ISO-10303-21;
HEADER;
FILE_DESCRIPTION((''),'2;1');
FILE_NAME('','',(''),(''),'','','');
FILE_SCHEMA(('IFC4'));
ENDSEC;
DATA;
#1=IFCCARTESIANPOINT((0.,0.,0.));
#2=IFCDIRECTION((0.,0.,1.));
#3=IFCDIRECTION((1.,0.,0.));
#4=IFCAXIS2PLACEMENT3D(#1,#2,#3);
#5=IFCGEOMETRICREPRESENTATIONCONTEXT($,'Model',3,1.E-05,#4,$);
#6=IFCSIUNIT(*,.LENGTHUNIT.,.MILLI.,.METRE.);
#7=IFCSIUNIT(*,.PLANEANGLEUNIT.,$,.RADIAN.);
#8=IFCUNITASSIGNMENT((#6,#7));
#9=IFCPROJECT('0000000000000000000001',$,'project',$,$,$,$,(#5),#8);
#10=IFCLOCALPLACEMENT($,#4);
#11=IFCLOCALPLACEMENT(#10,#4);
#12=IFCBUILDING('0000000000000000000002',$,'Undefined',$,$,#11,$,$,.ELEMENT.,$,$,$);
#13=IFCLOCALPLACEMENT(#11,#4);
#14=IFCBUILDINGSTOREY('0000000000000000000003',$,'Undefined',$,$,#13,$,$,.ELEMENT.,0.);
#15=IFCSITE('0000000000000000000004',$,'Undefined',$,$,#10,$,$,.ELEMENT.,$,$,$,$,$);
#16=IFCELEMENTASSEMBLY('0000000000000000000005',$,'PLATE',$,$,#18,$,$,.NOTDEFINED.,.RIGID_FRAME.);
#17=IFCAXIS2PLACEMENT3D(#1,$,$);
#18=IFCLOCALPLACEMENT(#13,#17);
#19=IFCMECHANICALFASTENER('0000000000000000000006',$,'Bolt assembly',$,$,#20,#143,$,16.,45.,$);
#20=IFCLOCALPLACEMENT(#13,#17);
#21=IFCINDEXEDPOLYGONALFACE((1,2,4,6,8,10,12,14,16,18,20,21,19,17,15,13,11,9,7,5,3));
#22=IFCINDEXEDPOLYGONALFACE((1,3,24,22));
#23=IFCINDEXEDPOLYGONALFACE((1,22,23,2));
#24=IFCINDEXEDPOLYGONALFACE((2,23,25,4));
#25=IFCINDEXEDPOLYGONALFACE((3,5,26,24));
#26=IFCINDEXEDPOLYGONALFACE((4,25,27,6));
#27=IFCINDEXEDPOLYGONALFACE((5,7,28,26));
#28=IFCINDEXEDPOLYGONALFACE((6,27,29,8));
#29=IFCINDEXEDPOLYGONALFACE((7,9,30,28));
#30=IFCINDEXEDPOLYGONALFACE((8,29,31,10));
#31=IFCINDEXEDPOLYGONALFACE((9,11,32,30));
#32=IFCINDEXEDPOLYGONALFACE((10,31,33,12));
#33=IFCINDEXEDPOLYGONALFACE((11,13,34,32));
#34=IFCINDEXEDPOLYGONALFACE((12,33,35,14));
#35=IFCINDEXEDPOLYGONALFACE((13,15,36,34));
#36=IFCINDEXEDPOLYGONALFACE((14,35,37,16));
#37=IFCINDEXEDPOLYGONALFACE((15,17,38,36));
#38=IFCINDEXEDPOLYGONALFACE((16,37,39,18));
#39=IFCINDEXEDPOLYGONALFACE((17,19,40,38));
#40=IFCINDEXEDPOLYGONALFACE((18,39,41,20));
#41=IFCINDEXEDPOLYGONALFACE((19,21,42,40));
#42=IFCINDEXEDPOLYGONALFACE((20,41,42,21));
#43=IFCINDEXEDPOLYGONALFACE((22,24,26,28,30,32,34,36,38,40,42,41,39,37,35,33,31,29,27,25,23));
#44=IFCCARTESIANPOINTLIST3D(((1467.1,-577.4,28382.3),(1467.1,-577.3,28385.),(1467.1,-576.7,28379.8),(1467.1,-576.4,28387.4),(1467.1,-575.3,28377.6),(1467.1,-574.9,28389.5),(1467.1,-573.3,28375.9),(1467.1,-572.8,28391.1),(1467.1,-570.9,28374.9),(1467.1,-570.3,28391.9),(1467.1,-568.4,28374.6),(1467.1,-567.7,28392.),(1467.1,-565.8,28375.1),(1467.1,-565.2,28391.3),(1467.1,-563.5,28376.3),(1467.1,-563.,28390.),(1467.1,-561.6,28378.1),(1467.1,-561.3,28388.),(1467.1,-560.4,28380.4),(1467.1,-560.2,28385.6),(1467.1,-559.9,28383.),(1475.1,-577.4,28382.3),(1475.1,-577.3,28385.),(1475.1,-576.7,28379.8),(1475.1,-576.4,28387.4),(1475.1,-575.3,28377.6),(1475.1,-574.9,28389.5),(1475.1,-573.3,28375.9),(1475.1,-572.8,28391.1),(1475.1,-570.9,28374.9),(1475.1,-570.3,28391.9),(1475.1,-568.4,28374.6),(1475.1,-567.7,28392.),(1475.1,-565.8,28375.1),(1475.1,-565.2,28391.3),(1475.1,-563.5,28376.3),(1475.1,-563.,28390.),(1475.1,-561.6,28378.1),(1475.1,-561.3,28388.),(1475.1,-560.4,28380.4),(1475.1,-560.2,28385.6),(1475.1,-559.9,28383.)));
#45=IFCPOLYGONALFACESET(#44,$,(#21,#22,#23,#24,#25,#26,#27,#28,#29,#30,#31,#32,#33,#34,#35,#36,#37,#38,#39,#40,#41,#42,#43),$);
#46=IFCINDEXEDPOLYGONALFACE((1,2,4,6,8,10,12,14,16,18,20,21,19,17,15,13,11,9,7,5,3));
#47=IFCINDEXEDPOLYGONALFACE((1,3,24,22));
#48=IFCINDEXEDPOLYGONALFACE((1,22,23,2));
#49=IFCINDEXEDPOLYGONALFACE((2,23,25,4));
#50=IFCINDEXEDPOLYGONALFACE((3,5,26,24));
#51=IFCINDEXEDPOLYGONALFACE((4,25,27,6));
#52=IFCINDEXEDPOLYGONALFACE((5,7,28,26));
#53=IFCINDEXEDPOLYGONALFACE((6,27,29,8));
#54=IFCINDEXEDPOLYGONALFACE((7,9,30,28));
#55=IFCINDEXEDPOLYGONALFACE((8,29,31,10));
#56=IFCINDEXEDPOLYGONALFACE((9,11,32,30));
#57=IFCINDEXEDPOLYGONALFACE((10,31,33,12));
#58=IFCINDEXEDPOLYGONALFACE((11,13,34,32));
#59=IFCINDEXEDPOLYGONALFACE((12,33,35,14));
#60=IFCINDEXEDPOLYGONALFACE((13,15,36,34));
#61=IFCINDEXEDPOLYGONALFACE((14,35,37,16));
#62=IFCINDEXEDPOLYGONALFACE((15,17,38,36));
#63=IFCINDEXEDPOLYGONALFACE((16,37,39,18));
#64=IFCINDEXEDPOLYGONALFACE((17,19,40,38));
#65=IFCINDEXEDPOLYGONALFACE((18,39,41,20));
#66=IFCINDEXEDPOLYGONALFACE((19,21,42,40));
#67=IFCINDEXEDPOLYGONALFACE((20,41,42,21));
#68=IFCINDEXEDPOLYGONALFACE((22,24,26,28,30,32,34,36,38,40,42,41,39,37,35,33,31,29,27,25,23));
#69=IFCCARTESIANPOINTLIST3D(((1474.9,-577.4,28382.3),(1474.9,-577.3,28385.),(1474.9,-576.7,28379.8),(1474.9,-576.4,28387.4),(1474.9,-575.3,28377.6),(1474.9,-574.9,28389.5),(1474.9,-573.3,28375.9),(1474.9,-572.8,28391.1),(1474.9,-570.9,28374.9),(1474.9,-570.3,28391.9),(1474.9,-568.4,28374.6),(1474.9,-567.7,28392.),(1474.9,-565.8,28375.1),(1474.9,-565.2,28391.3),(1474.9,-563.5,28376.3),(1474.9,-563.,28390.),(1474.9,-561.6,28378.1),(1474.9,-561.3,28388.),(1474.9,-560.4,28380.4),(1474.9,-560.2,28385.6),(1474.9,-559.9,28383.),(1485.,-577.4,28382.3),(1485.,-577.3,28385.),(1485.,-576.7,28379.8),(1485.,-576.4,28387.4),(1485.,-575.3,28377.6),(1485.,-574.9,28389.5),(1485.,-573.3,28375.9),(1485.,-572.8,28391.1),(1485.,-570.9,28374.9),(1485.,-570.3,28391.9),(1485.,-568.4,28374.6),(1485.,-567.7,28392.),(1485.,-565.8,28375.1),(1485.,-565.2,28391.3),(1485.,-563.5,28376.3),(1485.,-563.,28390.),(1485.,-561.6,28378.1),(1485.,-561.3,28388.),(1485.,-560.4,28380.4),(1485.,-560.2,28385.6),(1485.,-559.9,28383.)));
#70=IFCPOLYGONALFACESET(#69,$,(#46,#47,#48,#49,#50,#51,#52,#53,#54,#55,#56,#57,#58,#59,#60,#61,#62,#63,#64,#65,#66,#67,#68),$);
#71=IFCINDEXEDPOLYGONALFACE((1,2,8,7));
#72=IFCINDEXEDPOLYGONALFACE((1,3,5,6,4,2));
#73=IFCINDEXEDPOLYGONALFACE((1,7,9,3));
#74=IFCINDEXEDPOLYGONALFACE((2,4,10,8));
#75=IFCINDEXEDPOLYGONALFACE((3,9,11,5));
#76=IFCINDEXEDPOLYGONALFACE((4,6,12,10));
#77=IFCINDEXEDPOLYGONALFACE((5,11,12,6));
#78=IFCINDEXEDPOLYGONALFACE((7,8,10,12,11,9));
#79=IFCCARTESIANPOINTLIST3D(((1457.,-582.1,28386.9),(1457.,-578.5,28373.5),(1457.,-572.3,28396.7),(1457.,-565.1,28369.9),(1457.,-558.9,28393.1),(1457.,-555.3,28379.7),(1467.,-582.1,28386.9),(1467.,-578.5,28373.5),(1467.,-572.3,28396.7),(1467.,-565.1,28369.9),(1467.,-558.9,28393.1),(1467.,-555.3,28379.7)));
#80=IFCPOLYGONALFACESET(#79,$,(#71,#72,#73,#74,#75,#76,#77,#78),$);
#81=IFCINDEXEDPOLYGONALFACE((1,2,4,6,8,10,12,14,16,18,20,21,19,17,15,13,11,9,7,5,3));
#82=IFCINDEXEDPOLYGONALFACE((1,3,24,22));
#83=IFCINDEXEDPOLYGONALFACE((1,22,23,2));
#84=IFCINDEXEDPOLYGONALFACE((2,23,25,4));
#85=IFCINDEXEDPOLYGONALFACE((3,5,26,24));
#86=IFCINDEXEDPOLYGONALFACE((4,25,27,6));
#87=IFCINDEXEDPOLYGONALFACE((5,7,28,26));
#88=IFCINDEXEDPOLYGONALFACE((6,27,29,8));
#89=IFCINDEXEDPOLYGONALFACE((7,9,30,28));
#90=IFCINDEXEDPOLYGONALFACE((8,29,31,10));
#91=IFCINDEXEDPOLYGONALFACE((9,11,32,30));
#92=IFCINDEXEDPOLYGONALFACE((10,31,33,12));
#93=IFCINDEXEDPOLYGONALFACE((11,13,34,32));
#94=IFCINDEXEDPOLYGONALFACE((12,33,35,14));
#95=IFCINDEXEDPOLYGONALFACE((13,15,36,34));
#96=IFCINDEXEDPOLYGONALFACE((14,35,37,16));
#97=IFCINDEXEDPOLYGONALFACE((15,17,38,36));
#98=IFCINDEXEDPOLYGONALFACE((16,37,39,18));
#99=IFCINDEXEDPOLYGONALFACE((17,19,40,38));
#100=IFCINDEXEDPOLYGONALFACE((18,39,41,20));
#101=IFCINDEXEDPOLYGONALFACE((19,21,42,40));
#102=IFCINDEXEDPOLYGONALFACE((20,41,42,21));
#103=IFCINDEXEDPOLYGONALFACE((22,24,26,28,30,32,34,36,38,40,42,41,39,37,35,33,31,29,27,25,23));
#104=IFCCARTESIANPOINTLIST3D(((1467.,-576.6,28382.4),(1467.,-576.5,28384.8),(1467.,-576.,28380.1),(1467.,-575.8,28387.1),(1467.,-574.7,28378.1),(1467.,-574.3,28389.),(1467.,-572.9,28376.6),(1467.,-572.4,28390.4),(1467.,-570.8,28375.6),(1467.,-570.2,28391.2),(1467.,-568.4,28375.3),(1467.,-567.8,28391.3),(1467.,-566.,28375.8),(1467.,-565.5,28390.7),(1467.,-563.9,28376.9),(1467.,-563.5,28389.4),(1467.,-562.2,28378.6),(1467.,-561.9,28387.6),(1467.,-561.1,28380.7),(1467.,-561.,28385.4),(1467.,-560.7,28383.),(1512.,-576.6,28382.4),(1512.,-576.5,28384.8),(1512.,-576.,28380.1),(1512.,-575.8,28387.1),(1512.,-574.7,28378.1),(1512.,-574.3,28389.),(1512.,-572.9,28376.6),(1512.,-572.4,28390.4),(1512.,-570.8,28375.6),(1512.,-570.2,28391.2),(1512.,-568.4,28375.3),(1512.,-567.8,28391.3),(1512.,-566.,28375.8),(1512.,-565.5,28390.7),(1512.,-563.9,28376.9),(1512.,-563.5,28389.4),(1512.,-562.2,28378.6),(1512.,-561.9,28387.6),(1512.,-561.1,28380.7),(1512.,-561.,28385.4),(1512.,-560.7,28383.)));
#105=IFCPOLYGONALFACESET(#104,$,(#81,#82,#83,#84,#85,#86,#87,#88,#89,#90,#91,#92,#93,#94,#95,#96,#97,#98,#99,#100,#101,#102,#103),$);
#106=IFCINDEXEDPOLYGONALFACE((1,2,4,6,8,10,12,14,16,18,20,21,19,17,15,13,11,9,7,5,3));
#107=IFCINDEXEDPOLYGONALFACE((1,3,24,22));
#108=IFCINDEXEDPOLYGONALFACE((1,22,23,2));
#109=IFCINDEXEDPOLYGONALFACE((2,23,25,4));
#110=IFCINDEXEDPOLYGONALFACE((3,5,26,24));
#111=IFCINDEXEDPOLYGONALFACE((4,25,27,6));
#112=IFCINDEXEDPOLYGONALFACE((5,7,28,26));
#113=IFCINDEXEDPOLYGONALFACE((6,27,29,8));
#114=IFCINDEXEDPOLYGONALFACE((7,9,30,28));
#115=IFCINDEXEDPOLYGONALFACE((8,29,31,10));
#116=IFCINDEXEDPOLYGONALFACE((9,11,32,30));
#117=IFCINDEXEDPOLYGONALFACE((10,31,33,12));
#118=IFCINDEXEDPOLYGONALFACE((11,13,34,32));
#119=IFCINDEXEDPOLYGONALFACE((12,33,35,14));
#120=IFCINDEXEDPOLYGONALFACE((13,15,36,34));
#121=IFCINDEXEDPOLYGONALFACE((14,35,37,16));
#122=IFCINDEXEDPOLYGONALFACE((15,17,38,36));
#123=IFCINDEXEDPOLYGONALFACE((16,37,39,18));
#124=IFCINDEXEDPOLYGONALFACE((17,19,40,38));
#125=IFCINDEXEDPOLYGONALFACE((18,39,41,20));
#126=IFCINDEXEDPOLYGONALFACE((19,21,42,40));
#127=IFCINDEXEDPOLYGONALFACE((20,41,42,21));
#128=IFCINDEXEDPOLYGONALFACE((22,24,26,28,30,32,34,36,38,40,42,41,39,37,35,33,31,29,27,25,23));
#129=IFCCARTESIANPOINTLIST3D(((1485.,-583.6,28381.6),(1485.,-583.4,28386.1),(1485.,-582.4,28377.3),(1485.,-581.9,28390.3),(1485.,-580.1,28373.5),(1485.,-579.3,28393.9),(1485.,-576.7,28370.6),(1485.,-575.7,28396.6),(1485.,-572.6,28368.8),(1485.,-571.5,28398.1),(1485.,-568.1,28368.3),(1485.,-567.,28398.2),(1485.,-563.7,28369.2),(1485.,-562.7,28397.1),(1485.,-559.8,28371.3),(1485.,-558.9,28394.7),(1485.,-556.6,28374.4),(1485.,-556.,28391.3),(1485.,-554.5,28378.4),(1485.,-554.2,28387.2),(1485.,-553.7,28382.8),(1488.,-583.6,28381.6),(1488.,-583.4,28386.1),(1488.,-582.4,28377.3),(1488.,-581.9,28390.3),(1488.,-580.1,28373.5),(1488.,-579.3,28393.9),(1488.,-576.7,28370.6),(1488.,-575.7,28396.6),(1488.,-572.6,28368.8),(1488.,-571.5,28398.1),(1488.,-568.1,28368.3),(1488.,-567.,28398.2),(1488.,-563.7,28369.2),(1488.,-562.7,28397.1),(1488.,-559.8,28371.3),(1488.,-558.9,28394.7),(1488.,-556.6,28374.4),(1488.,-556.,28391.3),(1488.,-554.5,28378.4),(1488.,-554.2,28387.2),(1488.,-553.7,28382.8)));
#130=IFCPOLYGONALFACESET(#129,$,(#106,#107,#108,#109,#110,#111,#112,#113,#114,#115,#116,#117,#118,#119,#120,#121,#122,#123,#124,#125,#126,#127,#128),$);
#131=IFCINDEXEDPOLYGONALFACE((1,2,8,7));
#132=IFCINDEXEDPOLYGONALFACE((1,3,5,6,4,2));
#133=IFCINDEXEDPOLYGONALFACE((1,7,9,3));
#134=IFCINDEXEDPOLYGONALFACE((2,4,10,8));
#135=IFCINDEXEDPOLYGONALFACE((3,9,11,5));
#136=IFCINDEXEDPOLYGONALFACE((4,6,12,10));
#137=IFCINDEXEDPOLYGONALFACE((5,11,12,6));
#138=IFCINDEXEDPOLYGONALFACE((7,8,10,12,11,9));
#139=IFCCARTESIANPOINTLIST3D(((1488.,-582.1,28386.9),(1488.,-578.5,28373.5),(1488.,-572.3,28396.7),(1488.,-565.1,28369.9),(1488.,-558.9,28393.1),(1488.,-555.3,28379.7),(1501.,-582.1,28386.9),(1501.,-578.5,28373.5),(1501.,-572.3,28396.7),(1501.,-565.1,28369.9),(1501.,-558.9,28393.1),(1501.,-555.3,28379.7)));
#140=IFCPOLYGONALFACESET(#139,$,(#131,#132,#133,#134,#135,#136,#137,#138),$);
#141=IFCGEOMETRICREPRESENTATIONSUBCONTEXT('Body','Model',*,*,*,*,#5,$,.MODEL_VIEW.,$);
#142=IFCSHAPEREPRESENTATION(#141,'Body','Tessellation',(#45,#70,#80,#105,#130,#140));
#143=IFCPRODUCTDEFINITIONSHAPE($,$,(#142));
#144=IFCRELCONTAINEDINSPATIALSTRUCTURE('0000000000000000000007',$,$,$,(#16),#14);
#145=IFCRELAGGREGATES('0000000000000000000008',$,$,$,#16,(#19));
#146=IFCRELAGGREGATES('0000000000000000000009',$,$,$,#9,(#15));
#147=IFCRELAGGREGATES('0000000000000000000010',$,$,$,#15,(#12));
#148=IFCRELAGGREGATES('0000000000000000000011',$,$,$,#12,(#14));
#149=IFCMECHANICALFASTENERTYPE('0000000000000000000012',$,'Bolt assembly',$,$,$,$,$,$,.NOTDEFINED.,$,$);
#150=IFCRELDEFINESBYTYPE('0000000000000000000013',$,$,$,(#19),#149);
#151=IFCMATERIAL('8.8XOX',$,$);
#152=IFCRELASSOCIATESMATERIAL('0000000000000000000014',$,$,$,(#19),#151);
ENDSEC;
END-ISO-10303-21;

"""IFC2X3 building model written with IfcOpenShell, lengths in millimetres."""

from ifc_helpers import new_model, si_unit, frame, origin_with_axes, origin_2d_with_axis, place, context, subcontext, project, spatial, polyline, circle, outline, extrude, source, transform, mapped, material, type_object, element, aggregate, save


model = new_model("IFC2X3")

# Units and contexts
model_context = context("Model", 3, precision=1e-05, world=origin_with_axes())
body_context = subcontext(model_context, "Body", "Model", "MODEL_VIEW")
ifc_project = project(units=[si_unit("LENGTHUNIT", "METRE", prefix="MILLI"), si_unit("PLANEANGLEUNIT", "RADIAN")], contexts=[model_context])

# Site, building, storey
site_placement = place(None, origin_with_axes())
site = spatial("IfcSite", under=ifc_project, at=site_placement, Name="Undefined", CompositionType="ELEMENT")
building_placement = place(site_placement, origin_with_axes())
building = spatial("IfcBuilding", under=site, at=building_placement, Name="Undefined", CompositionType="ELEMENT")
storey_placement = place(building_placement, origin_with_axes())
storey = spatial("IfcBuildingStorey", under=building, at=storey_placement, Name="Undefined", CompositionType="ELEMENT", Elevation=0.0)

# Element assembly
assembly_1_placement = place(storey_placement, origin_with_axes())
assembly_1 = element("IfcElementAssembly", 1, at=assembly_1_placement, inside=storey, Name="PLATE", AssemblyPlace="NOTDEFINED", PredefinedType="RIGID_FRAME")

# Mechanical fastener
ifc_material_1 = material(Name="8.8XOX")
mechanical_fastener_type = type_object("IfcMechanicalFastenerType", Name="Bolt assembly")
shared_shape_1 = source(origin_with_axes(), body_context, "Body", "SweptSolid", [
    extrude(circle(Radius=8.8, at=origin_2d_with_axis()), frame((0.0, 7.1, 0.0), z_axis=(0.0, 1.0, 0.0), x_axis=(1.0, 0.0, 0.0)), (0.0, 0.0, 1.0), 8.0),
    extrude(circle(Radius=8.8, at=origin_2d_with_axis()), frame((0.0, 14.9, 0.0), z_axis=(0.0, 1.0, 0.0), x_axis=(1.0, 0.0, 0.0)), (0.0, 0.0, 1.0), 10.1),
    extrude(outline(polyline([(12.0, -6.9), (12.0, 6.9), (0.0, 13.9), (-12.0, 6.9), (-12.0, -6.9), (0.0, -13.9), (12.0, -6.9)])), frame((0.0, -3.0, 0.0), z_axis=(0.0, 1.0, 0.0), x_axis=(1.0, 0.0, 0.0)), (0.0, 0.0, 1.0), 10.0),
    extrude(circle(Radius=8.0, at=origin_2d_with_axis()), frame((0.0, 7.0, 0.0), z_axis=(0.0, 1.0, 0.0), x_axis=(1.0, 0.0, 0.0)), (0.0, 0.0, 1.0), 45.0),
    extrude(circle(Radius=15.0, at=origin_2d_with_axis()), frame((0.0, 25.0, 0.0), z_axis=(0.0, 1.0, 0.0), x_axis=(1.0, 0.0, 0.0)), (0.0, 0.0, 1.0), 3.0),
    extrude(outline(polyline([(12.0, -6.9), (12.0, 6.9), (0.0, 13.9), (-12.0, 6.9), (-12.0, -6.9), (0.0, -13.9), (12.0, -6.9)])), frame((0.0, 28.0, 0.0), z_axis=(0.0, 1.0, 0.0), x_axis=(1.0, 0.0, 0.0)), (0.0, 0.0, 1.0), 13.0),
])
mechanical_fastener_1_placement = place(assembly_1_placement, frame((1460.0, -568.7, 28383.3), z_axis=(0.0, 0.707107, 0.707107), x_axis=(0.0, -0.707107, 0.707107)))
mechanical_fastener_1 = element("IfcMechanicalFastener", 2, at=mechanical_fastener_1_placement, type_object=mechanical_fastener_type, material=ifc_material_1, Name="Bolt assembly", NominalDiameter=16.0, NominalLength=45.0, context=body_context, shape_type="MappedRepresentation", body=[
    mapped(shared_shape_1, transform((0.0, 0.0, 0.0))),
])
aggregate(assembly_1, [mechanical_fastener_1])

save(model, "model.ifc")
